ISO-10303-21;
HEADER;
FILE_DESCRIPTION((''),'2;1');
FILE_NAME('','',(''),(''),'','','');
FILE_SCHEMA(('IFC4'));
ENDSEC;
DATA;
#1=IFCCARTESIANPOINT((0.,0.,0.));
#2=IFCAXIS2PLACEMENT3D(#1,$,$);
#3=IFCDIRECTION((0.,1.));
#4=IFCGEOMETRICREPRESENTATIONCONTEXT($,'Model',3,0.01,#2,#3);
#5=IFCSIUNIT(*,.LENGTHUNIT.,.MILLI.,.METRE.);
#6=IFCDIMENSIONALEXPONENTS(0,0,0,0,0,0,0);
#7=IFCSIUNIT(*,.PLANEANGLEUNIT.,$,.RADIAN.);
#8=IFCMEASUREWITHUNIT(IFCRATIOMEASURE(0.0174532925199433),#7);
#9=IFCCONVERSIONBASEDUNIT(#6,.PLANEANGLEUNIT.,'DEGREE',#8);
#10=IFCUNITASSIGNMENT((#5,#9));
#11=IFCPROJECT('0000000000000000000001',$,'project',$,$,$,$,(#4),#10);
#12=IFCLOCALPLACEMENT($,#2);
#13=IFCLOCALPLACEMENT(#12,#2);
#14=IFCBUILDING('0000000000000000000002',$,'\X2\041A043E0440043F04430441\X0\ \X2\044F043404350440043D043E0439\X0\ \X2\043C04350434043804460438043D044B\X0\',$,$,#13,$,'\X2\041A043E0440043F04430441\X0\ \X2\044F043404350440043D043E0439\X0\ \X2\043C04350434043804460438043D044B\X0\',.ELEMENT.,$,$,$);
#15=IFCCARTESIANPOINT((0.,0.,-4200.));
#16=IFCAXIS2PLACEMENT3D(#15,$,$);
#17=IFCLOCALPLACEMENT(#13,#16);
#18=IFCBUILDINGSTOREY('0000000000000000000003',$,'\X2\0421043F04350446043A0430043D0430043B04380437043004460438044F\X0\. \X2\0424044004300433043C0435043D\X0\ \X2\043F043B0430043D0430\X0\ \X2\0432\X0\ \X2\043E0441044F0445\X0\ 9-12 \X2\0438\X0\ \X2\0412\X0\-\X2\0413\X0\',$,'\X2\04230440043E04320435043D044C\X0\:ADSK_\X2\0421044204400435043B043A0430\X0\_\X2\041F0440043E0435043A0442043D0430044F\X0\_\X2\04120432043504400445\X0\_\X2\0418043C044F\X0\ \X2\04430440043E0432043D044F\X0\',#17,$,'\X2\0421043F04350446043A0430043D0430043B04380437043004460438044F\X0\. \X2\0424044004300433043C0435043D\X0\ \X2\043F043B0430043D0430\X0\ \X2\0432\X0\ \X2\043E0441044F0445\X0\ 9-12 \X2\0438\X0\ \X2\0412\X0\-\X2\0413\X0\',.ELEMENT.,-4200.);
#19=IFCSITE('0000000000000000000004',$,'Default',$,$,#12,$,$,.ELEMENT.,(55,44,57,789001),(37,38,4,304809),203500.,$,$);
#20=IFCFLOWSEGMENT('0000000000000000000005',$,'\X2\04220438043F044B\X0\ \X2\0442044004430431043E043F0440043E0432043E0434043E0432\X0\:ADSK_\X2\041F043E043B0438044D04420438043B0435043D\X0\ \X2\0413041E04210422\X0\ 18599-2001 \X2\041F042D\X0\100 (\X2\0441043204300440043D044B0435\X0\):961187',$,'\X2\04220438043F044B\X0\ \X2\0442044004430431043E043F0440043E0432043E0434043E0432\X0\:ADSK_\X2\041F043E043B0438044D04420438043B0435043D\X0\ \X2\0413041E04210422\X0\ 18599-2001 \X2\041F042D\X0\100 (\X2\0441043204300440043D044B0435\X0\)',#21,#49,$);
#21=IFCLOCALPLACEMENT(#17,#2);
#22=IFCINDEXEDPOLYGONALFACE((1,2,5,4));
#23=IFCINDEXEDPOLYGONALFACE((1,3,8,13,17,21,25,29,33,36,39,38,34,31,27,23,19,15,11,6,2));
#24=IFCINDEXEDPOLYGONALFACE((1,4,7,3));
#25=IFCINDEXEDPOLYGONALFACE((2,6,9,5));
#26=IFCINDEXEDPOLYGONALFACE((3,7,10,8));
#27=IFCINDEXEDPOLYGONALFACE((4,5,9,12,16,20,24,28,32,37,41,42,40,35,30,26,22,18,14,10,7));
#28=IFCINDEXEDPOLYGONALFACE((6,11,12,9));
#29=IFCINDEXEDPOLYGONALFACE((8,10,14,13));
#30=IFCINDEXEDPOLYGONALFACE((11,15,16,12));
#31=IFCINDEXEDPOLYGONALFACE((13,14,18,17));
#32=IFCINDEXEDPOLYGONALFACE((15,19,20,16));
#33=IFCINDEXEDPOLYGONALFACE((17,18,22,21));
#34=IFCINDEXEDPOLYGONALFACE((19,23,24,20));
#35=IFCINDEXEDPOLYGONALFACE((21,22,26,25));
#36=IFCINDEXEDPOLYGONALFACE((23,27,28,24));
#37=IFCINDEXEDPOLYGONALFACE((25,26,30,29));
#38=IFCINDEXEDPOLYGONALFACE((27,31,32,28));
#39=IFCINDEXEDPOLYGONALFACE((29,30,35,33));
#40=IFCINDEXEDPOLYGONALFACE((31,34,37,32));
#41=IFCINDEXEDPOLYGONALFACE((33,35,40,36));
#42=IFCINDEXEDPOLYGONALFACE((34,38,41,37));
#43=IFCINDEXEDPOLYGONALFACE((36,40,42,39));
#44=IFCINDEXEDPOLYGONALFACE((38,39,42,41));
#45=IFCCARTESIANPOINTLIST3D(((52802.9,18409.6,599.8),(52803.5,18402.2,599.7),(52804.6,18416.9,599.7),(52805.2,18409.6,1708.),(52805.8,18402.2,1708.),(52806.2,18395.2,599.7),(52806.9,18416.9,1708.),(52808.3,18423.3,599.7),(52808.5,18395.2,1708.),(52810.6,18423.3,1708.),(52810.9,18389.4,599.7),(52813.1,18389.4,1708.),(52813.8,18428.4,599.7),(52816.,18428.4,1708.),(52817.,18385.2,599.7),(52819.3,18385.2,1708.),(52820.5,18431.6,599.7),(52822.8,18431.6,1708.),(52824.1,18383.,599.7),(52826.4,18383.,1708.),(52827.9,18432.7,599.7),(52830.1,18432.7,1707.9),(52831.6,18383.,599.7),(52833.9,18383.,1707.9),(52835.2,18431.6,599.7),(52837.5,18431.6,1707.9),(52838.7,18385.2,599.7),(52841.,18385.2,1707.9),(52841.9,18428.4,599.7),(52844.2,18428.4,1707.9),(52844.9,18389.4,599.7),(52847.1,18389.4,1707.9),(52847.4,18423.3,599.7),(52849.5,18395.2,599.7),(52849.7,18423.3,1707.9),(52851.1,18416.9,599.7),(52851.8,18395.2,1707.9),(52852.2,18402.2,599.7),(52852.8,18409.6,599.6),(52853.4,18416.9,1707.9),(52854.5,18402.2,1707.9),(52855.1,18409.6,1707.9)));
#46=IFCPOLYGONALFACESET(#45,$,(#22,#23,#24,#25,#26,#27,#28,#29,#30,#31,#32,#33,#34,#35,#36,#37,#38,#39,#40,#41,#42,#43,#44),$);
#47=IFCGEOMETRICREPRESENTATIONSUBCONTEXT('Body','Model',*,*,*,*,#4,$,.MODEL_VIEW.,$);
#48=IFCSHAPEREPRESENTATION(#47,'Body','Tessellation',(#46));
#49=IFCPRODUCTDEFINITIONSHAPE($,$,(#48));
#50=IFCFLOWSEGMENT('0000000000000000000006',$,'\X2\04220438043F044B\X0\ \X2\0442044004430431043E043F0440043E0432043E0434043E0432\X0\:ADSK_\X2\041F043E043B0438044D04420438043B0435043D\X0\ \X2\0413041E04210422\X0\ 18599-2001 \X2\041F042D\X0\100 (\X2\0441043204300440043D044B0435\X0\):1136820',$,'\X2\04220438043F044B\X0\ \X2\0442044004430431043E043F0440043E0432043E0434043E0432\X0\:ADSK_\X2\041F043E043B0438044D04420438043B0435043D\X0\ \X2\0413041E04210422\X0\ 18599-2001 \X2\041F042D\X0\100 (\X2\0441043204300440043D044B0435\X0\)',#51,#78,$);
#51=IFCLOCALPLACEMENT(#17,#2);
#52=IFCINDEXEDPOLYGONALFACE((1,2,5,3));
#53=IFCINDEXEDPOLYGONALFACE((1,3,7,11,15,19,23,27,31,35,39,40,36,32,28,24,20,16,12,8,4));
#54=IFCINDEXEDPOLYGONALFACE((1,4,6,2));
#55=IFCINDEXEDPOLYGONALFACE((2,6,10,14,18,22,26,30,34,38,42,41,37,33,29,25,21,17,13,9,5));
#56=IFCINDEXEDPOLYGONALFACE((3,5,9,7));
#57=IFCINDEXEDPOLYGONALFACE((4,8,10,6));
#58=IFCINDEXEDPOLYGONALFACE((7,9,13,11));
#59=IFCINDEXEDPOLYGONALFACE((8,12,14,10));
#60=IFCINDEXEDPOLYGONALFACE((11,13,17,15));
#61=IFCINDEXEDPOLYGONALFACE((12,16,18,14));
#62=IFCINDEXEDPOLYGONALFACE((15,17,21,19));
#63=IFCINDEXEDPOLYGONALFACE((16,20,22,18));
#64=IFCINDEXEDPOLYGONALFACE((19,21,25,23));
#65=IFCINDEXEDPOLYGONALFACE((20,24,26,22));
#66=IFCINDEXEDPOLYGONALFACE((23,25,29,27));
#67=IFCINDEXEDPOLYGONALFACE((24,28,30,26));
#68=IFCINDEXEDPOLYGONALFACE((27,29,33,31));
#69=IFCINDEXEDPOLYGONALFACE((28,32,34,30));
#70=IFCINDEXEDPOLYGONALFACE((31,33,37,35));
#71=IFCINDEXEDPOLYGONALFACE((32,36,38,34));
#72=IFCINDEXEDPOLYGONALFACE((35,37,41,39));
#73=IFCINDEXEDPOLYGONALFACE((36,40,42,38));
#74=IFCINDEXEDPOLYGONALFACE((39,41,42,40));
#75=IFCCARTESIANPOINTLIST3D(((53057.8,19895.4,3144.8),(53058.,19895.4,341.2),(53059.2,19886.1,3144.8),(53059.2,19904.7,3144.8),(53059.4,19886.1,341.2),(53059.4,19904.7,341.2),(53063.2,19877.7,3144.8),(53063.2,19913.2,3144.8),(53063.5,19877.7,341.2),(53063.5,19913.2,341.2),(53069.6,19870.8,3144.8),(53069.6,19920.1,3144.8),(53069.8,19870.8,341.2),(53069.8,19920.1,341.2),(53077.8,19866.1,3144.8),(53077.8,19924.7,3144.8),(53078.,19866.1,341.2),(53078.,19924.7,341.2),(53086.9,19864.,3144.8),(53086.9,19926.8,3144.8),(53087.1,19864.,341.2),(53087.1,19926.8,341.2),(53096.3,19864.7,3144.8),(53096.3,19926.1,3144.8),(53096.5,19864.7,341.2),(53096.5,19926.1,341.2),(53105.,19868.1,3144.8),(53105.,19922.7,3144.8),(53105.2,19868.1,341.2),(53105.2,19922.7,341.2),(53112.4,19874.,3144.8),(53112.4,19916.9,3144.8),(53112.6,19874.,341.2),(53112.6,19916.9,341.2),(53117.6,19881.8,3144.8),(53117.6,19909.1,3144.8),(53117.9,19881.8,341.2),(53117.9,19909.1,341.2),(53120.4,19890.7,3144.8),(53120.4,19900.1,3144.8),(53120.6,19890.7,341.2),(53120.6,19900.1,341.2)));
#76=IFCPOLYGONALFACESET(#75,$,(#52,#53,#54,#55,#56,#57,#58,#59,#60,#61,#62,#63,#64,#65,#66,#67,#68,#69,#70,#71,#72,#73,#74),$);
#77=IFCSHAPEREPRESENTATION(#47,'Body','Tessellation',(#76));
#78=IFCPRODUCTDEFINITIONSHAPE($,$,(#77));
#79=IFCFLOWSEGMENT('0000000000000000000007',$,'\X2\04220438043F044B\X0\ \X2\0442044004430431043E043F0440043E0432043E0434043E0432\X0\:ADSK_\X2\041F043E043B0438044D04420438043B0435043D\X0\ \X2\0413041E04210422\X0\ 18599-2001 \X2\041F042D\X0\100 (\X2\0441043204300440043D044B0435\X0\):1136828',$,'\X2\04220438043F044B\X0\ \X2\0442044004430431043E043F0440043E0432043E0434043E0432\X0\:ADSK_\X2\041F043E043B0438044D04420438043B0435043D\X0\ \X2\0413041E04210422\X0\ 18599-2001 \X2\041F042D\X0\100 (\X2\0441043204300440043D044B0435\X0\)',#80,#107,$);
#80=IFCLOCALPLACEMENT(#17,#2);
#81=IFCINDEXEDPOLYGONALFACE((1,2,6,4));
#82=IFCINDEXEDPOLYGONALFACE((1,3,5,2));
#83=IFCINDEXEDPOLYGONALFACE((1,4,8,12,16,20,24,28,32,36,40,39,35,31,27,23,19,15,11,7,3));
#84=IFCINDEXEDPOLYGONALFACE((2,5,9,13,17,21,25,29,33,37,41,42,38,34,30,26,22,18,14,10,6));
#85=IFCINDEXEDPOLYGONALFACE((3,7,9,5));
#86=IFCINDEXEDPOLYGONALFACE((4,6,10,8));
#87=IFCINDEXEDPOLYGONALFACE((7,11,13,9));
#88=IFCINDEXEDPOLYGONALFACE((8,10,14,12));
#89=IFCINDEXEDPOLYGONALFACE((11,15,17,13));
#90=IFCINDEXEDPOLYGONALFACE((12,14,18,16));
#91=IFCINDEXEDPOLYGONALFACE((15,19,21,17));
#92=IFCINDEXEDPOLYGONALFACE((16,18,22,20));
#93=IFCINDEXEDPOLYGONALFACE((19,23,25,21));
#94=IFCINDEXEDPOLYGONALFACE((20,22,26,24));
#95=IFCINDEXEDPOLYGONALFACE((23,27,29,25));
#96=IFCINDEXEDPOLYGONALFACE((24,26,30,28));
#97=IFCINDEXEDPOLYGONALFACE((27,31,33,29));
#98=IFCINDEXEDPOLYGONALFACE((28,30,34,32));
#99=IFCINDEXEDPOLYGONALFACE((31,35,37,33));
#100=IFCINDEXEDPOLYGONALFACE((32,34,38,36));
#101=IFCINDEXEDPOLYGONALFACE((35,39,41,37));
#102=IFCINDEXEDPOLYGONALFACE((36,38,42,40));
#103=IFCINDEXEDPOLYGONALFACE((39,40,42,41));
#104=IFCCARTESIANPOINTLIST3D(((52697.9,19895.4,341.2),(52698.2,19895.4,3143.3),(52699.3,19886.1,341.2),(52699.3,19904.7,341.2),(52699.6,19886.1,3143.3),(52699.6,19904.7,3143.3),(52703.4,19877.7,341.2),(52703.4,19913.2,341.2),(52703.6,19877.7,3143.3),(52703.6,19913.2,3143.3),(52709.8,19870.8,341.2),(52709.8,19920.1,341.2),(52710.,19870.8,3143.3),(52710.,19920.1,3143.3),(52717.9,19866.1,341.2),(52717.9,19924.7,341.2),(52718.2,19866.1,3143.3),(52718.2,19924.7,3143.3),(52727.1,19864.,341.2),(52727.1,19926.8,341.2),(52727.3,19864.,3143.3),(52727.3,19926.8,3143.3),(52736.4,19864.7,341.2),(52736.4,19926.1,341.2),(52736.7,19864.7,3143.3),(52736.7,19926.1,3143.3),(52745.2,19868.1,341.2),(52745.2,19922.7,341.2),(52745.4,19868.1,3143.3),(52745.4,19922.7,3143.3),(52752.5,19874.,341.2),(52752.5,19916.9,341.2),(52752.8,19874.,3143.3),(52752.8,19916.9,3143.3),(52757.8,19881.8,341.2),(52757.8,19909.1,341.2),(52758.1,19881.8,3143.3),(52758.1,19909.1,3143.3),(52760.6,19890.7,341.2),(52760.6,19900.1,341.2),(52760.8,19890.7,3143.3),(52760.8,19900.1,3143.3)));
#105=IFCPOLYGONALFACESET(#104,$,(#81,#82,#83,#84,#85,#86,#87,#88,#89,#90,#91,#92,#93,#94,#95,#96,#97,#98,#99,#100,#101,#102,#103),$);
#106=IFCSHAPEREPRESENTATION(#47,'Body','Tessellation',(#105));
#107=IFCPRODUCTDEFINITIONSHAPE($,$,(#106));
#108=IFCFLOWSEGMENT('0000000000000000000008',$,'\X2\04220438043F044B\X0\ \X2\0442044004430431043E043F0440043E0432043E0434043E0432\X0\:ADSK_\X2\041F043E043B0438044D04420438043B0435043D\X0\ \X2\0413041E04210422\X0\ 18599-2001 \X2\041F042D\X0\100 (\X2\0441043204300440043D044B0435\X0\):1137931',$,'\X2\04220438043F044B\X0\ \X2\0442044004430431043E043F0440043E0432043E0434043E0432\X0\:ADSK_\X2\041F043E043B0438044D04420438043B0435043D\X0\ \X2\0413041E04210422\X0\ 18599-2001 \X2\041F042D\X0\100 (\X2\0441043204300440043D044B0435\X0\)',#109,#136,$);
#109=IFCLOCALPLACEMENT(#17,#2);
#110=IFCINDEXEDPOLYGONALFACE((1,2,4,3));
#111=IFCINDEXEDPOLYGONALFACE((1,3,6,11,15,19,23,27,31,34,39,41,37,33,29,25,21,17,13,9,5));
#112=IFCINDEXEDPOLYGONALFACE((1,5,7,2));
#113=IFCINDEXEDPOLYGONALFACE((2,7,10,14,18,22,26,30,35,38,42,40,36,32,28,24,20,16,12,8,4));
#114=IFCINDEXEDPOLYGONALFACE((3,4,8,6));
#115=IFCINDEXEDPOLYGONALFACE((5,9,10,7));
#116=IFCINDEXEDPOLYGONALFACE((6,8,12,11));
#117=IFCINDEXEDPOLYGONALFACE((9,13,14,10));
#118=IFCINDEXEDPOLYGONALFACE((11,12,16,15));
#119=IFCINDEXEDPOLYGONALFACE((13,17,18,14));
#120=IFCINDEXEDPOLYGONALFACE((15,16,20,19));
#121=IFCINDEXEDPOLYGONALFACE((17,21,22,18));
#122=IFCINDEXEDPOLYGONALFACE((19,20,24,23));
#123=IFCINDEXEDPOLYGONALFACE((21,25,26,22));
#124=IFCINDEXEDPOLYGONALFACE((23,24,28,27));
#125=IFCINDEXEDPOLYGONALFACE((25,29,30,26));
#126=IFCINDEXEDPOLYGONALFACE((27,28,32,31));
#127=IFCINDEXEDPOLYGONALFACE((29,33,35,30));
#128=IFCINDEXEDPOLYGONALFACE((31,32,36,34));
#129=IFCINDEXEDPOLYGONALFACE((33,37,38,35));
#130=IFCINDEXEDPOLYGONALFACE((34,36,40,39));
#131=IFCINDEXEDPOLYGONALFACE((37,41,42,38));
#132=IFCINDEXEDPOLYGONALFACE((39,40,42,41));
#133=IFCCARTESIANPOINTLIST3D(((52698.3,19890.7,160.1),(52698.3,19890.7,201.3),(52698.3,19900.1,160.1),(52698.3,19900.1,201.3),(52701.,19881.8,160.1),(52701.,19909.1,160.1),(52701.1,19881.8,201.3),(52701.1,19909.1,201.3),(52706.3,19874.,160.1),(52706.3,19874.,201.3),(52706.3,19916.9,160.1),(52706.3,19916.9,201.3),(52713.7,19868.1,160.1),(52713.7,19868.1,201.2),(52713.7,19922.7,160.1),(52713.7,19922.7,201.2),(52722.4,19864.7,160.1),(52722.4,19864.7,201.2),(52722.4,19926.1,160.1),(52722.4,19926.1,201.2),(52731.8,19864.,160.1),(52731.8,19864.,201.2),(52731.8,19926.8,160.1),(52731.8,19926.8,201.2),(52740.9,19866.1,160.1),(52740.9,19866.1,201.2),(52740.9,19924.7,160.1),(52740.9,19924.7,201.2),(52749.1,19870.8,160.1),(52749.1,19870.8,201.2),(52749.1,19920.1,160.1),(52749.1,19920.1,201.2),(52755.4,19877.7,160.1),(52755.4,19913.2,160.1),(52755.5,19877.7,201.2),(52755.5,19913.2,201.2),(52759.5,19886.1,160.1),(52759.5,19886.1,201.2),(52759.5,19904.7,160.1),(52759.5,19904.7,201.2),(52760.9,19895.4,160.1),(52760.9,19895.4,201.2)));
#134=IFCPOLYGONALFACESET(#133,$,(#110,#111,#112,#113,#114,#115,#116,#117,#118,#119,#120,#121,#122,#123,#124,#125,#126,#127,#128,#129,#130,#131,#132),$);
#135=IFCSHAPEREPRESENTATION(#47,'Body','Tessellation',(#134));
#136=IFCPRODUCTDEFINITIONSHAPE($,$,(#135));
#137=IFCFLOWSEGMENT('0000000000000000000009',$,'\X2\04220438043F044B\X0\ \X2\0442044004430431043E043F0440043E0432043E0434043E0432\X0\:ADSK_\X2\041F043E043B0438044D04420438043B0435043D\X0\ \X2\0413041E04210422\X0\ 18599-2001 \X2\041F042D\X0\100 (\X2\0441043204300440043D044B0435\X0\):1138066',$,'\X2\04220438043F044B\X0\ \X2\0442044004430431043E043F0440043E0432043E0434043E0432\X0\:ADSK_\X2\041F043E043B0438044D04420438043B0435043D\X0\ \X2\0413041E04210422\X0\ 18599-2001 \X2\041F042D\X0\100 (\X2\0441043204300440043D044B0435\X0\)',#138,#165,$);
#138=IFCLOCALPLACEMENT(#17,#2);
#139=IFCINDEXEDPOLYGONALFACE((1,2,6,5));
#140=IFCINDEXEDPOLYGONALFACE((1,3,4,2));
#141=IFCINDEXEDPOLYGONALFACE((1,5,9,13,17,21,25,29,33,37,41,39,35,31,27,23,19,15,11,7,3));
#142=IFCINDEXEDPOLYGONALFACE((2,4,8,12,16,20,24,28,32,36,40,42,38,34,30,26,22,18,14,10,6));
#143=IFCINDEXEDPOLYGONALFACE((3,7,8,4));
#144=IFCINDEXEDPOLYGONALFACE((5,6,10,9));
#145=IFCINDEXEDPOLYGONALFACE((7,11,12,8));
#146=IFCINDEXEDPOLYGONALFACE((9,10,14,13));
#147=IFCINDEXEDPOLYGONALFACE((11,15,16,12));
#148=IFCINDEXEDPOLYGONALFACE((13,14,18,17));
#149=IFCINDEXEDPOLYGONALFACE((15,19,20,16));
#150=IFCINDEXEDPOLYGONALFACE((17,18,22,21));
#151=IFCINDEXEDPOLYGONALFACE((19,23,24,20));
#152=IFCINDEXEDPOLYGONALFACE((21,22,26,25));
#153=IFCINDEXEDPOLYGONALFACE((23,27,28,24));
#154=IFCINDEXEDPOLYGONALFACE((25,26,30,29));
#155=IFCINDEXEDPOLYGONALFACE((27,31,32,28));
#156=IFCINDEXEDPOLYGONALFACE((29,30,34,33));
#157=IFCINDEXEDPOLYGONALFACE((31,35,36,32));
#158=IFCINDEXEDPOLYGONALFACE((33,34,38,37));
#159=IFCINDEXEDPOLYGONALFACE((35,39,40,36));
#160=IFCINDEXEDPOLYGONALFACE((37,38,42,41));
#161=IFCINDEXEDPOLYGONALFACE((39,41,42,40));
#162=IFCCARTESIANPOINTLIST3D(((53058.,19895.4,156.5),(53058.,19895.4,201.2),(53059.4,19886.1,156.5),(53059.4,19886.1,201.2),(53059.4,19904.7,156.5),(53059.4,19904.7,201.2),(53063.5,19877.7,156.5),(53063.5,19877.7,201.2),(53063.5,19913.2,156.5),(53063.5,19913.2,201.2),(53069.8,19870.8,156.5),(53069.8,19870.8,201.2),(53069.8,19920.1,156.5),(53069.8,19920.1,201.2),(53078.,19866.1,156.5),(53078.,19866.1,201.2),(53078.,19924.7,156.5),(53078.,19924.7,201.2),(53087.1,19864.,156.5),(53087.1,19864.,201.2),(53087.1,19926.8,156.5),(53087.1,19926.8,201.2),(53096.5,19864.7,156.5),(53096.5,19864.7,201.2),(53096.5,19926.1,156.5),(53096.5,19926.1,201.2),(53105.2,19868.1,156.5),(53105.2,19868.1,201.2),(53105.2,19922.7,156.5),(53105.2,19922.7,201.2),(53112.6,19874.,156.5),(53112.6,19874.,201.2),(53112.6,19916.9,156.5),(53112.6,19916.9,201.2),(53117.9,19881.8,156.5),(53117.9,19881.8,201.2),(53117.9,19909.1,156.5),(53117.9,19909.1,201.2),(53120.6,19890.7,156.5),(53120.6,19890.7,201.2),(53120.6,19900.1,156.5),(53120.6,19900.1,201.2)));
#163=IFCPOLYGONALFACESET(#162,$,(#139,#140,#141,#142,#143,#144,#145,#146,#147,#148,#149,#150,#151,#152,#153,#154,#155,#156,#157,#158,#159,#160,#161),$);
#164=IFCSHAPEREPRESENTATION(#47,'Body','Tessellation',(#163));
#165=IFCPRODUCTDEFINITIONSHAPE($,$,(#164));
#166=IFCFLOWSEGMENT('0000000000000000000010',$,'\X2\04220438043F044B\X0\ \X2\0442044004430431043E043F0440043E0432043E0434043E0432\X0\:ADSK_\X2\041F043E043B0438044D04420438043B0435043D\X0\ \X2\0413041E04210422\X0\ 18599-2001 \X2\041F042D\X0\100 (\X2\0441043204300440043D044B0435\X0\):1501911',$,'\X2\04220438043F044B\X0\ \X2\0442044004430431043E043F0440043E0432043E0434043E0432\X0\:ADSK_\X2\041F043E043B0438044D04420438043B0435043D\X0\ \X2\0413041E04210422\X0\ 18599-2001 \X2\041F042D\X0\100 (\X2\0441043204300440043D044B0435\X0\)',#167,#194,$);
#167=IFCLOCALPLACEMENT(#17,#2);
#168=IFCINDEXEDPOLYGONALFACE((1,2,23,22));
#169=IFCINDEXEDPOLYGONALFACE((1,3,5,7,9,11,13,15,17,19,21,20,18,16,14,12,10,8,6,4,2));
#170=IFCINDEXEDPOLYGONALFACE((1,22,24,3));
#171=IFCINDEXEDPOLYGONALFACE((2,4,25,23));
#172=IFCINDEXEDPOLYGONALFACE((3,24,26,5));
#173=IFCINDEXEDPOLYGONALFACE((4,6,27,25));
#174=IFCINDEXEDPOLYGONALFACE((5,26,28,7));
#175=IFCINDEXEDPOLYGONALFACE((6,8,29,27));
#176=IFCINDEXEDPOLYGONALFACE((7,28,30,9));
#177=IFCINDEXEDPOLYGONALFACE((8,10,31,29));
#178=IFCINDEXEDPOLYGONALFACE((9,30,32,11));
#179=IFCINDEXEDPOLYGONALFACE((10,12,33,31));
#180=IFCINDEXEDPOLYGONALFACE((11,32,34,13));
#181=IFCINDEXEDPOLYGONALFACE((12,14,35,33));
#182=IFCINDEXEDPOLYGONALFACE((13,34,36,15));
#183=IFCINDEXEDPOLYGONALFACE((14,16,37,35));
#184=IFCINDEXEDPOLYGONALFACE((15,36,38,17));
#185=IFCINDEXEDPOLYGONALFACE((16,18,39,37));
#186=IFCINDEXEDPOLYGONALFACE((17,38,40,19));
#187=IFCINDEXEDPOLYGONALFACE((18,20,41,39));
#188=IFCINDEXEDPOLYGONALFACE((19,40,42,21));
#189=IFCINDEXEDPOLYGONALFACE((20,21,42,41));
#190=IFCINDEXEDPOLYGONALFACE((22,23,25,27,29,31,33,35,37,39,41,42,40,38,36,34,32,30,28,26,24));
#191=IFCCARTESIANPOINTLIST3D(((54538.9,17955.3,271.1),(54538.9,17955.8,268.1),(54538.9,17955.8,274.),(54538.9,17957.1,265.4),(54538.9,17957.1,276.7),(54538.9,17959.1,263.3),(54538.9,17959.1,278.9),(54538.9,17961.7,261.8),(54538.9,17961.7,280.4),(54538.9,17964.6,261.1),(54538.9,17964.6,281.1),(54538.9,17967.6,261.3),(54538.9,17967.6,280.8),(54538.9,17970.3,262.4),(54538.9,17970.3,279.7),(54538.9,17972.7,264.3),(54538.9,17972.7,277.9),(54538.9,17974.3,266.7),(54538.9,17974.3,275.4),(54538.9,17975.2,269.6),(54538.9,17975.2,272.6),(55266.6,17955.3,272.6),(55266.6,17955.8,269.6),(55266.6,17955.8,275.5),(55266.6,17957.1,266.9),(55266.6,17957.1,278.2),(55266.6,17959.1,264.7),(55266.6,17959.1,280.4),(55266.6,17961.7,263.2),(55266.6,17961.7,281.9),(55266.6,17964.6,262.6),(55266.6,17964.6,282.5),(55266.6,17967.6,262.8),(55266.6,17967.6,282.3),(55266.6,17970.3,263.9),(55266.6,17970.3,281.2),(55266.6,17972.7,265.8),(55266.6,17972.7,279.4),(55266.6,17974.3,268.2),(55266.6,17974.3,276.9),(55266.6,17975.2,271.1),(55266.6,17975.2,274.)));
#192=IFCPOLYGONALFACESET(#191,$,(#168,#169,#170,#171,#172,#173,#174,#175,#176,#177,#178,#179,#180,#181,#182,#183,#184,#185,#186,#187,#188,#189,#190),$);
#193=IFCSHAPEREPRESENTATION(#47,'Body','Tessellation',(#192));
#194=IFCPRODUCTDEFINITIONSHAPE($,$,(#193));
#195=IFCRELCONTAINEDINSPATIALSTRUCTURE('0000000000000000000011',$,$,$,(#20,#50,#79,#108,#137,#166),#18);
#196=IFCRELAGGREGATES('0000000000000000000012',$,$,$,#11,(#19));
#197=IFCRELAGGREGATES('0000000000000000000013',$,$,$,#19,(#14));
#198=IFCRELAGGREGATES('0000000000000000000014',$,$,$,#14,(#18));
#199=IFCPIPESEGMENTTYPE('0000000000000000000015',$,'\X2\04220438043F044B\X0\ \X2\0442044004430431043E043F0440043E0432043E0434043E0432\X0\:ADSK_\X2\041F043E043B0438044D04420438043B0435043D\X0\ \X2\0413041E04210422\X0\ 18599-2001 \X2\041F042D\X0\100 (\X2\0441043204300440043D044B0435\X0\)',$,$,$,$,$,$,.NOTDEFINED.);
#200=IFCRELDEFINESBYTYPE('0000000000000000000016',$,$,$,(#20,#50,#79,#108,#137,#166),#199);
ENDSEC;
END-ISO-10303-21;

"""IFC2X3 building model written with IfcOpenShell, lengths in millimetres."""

from ifc_helpers import new_model, entity, si_unit, converted_unit, direction, frame, frame_2d, origin, origin_2d_with_axis, place, context, subcontext, project, spatial, circle, extrude, type_object, element, save


model = new_model("IFC2X3")

# Units and contexts
model_context = context("Model", 3, precision=0.01, world=origin(), true_north=direction((0.0, 1.0)))
body_context = subcontext(model_context, "Body", "Model", "MODEL_VIEW")
ifc_project = project(units=[si_unit("LENGTHUNIT", "METRE", prefix="MILLI"), converted_unit("PLANEANGLEUNIT", "DEGREE", entity("IfcRatioMeasure", 0.0174532925199433), si_unit("PLANEANGLEUNIT", "RADIAN"), dimensions=[0, 0, 0, 0, 0, 0, 0])], contexts=[model_context])

# Site, building, storey
site_placement = place(None, frame((0.0, 0.0, 0.0)))
site = spatial("IfcSite", under=ifc_project, at=site_placement, Name="Default", CompositionType="ELEMENT", RefLatitude=(55, 44, 57, 789001), RefLongitude=(37, 38, 4, 304809), RefElevation=203500.0)
building_placement = place(site_placement, origin())
building = spatial("IfcBuilding", under=site, at=building_placement, Name="Корпус ядерной медицины", LongName="Корпус ядерной медицины", CompositionType="ELEMENT")
storey_placement = place(building_placement, frame((0.0, 0.0, -4200.0)))
storey = spatial("IfcBuildingStorey", under=building, at=storey_placement, Name="Спецканализация. Фрагмен плана в осях 9-12 и В-Г", ObjectType="Уровень:ADSK_Стрелка_Проектная_Вверх_Имя уровня", LongName="Спецканализация. Фрагмен плана в осях 9-12 и В-Г", CompositionType="ELEMENT", Elevation=-4200.0)

# Flow segments
pipe_segment_type = type_object("IfcPipeSegmentType", Name="Типы трубопроводов:ADSK_Полиэтилен ГОСТ 18599-2001 ПЭ100 (сварные)", PredefinedType="NOTDEFINED")
flow_segment_1_placement = place(storey_placement, frame((52801.3, 18381.1, 599.6)))
element("IfcFlowSegment", 1, at=flow_segment_1_placement, inside=storey, type_object=pipe_segment_type, Name="Типы трубопроводов:ADSK_Полиэтилен ГОСТ 18599-2001 ПЭ100 (сварные):961187", ObjectType="Типы трубопроводов:ADSK_Полиэтилен ГОСТ 18599-2001 ПЭ100 (сварные)", context=body_context, shape_type="SweptSolid", body=[
    extrude(circle(Radius=25.0, at=origin_2d_with_axis()), frame((26.6, 26.6, 0.1), z_axis=(0.002045, 0.000001, 0.999998), x_axis=(-0.000266, 1.0, 0.0)), (0.0, 0.0, 1.0), 1108.3),
])
flow_segment_2_placement = place(storey_placement, frame((53056.2, 19862.3, 341.2)))
element("IfcFlowSegment", 2, at=flow_segment_2_placement, inside=storey, type_object=pipe_segment_type, Name="Типы трубопроводов:ADSK_Полиэтилен ГОСТ 18599-2001 ПЭ100 (сварные):1136820", ObjectType="Типы трубопроводов:ADSK_Полиэтилен ГОСТ 18599-2001 ПЭ100 (сварные)", context=body_context, shape_type="SweptSolid", body=[
    extrude(circle(Radius=31.5, at=origin_2d_with_axis()), frame((33.3, 33.1, 0.0), z_axis=(-0.00008, 0.0, 1.0), x_axis=(-1.0, 0.0, -0.00008)), (0.0, 0.0, 1.0), 2803.6),
])
flow_segment_3_placement = place(storey_placement, frame((52696.3, 19862.3, 341.2)))
element("IfcFlowSegment", 3, at=flow_segment_3_placement, inside=storey, type_object=pipe_segment_type, Name="Типы трубопроводов:ADSK_Полиэтилен ГОСТ 18599-2001 ПЭ100 (сварные):1136828", ObjectType="Типы трубопроводов:ADSK_Полиэтилен ГОСТ 18599-2001 ПЭ100 (сварные)", context=body_context, shape_type="SweptSolid", body=[
    extrude(circle(Radius=31.5, at=frame_2d((0.0, 0.0), x_axis=(1.0, 0.0))), frame((33.1, 33.1, 0.0), z_axis=(0.000084, 0.0, 1.0), x_axis=(-1.0, 0.0, 0.000084)), (0.0, 0.0, 1.0), 2802.1),
])
flow_segment_4_placement = place(storey_placement, frame((52696.3, 19862.3, 160.1)))
element("IfcFlowSegment", 4, at=flow_segment_4_placement, inside=storey, type_object=pipe_segment_type, Name="Типы трубопроводов:ADSK_Полиэтилен ГОСТ 18599-2001 ПЭ100 (сварные):1137931", ObjectType="Типы трубопроводов:ADSK_Полиэтилен ГОСТ 18599-2001 ПЭ100 (сварные)", context=body_context, shape_type="SweptSolid", body=[
    extrude(circle(Radius=31.5, at=origin_2d_with_axis()), frame((33.1, 33.1, 0.0), z_axis=(0.000569, 0.0, 1.0), x_axis=(1.0, 0.0, -0.000569)), (0.0, 0.0, 1.0), 41.1),
])
flow_segment_5_placement = place(storey_placement, frame((53056.4, 19862.3, 156.5)))
element("IfcFlowSegment", 5, at=flow_segment_5_placement, inside=storey, type_object=pipe_segment_type, Name="Типы трубопроводов:ADSK_Полиэтилен ГОСТ 18599-2001 ПЭ100 (сварные):1138066", ObjectType="Типы трубопроводов:ADSK_Полиэтилен ГОСТ 18599-2001 ПЭ100 (сварные)", context=body_context, shape_type="SweptSolid", body=[
    extrude(circle(Radius=31.5, at=origin_2d_with_axis()), frame((33.1, 33.1, 0.0), z_axis=(0.000002, 0.0, 1.0), x_axis=(-1.0, 0.0, 0.000002)), (0.0, 0.0, 1.0), 44.7),
])
flow_segment_6_placement = place(storey_placement, frame((54538.9, 17953.7, 259.5)))
element("IfcFlowSegment", 6, at=flow_segment_6_placement, inside=storey, type_object=pipe_segment_type, Name="Типы трубопроводов:ADSK_Полиэтилен ГОСТ 18599-2001 ПЭ100 (сварные):1501911", ObjectType="Типы трубопроводов:ADSK_Полиэтилен ГОСТ 18599-2001 ПЭ100 (сварные)", context=body_context, shape_type="SweptSolid", body=[
    extrude(circle(Radius=10.0, at=origin_2d_with_axis()), frame((0.0, 11.6, 11.6), z_axis=(0.999998, 0.000004, 0.002027), x_axis=(0.000004, -1.0, 0.0)), (0.0, 0.0, 1.0), 727.7),
])

save(model, "model.ifc")
